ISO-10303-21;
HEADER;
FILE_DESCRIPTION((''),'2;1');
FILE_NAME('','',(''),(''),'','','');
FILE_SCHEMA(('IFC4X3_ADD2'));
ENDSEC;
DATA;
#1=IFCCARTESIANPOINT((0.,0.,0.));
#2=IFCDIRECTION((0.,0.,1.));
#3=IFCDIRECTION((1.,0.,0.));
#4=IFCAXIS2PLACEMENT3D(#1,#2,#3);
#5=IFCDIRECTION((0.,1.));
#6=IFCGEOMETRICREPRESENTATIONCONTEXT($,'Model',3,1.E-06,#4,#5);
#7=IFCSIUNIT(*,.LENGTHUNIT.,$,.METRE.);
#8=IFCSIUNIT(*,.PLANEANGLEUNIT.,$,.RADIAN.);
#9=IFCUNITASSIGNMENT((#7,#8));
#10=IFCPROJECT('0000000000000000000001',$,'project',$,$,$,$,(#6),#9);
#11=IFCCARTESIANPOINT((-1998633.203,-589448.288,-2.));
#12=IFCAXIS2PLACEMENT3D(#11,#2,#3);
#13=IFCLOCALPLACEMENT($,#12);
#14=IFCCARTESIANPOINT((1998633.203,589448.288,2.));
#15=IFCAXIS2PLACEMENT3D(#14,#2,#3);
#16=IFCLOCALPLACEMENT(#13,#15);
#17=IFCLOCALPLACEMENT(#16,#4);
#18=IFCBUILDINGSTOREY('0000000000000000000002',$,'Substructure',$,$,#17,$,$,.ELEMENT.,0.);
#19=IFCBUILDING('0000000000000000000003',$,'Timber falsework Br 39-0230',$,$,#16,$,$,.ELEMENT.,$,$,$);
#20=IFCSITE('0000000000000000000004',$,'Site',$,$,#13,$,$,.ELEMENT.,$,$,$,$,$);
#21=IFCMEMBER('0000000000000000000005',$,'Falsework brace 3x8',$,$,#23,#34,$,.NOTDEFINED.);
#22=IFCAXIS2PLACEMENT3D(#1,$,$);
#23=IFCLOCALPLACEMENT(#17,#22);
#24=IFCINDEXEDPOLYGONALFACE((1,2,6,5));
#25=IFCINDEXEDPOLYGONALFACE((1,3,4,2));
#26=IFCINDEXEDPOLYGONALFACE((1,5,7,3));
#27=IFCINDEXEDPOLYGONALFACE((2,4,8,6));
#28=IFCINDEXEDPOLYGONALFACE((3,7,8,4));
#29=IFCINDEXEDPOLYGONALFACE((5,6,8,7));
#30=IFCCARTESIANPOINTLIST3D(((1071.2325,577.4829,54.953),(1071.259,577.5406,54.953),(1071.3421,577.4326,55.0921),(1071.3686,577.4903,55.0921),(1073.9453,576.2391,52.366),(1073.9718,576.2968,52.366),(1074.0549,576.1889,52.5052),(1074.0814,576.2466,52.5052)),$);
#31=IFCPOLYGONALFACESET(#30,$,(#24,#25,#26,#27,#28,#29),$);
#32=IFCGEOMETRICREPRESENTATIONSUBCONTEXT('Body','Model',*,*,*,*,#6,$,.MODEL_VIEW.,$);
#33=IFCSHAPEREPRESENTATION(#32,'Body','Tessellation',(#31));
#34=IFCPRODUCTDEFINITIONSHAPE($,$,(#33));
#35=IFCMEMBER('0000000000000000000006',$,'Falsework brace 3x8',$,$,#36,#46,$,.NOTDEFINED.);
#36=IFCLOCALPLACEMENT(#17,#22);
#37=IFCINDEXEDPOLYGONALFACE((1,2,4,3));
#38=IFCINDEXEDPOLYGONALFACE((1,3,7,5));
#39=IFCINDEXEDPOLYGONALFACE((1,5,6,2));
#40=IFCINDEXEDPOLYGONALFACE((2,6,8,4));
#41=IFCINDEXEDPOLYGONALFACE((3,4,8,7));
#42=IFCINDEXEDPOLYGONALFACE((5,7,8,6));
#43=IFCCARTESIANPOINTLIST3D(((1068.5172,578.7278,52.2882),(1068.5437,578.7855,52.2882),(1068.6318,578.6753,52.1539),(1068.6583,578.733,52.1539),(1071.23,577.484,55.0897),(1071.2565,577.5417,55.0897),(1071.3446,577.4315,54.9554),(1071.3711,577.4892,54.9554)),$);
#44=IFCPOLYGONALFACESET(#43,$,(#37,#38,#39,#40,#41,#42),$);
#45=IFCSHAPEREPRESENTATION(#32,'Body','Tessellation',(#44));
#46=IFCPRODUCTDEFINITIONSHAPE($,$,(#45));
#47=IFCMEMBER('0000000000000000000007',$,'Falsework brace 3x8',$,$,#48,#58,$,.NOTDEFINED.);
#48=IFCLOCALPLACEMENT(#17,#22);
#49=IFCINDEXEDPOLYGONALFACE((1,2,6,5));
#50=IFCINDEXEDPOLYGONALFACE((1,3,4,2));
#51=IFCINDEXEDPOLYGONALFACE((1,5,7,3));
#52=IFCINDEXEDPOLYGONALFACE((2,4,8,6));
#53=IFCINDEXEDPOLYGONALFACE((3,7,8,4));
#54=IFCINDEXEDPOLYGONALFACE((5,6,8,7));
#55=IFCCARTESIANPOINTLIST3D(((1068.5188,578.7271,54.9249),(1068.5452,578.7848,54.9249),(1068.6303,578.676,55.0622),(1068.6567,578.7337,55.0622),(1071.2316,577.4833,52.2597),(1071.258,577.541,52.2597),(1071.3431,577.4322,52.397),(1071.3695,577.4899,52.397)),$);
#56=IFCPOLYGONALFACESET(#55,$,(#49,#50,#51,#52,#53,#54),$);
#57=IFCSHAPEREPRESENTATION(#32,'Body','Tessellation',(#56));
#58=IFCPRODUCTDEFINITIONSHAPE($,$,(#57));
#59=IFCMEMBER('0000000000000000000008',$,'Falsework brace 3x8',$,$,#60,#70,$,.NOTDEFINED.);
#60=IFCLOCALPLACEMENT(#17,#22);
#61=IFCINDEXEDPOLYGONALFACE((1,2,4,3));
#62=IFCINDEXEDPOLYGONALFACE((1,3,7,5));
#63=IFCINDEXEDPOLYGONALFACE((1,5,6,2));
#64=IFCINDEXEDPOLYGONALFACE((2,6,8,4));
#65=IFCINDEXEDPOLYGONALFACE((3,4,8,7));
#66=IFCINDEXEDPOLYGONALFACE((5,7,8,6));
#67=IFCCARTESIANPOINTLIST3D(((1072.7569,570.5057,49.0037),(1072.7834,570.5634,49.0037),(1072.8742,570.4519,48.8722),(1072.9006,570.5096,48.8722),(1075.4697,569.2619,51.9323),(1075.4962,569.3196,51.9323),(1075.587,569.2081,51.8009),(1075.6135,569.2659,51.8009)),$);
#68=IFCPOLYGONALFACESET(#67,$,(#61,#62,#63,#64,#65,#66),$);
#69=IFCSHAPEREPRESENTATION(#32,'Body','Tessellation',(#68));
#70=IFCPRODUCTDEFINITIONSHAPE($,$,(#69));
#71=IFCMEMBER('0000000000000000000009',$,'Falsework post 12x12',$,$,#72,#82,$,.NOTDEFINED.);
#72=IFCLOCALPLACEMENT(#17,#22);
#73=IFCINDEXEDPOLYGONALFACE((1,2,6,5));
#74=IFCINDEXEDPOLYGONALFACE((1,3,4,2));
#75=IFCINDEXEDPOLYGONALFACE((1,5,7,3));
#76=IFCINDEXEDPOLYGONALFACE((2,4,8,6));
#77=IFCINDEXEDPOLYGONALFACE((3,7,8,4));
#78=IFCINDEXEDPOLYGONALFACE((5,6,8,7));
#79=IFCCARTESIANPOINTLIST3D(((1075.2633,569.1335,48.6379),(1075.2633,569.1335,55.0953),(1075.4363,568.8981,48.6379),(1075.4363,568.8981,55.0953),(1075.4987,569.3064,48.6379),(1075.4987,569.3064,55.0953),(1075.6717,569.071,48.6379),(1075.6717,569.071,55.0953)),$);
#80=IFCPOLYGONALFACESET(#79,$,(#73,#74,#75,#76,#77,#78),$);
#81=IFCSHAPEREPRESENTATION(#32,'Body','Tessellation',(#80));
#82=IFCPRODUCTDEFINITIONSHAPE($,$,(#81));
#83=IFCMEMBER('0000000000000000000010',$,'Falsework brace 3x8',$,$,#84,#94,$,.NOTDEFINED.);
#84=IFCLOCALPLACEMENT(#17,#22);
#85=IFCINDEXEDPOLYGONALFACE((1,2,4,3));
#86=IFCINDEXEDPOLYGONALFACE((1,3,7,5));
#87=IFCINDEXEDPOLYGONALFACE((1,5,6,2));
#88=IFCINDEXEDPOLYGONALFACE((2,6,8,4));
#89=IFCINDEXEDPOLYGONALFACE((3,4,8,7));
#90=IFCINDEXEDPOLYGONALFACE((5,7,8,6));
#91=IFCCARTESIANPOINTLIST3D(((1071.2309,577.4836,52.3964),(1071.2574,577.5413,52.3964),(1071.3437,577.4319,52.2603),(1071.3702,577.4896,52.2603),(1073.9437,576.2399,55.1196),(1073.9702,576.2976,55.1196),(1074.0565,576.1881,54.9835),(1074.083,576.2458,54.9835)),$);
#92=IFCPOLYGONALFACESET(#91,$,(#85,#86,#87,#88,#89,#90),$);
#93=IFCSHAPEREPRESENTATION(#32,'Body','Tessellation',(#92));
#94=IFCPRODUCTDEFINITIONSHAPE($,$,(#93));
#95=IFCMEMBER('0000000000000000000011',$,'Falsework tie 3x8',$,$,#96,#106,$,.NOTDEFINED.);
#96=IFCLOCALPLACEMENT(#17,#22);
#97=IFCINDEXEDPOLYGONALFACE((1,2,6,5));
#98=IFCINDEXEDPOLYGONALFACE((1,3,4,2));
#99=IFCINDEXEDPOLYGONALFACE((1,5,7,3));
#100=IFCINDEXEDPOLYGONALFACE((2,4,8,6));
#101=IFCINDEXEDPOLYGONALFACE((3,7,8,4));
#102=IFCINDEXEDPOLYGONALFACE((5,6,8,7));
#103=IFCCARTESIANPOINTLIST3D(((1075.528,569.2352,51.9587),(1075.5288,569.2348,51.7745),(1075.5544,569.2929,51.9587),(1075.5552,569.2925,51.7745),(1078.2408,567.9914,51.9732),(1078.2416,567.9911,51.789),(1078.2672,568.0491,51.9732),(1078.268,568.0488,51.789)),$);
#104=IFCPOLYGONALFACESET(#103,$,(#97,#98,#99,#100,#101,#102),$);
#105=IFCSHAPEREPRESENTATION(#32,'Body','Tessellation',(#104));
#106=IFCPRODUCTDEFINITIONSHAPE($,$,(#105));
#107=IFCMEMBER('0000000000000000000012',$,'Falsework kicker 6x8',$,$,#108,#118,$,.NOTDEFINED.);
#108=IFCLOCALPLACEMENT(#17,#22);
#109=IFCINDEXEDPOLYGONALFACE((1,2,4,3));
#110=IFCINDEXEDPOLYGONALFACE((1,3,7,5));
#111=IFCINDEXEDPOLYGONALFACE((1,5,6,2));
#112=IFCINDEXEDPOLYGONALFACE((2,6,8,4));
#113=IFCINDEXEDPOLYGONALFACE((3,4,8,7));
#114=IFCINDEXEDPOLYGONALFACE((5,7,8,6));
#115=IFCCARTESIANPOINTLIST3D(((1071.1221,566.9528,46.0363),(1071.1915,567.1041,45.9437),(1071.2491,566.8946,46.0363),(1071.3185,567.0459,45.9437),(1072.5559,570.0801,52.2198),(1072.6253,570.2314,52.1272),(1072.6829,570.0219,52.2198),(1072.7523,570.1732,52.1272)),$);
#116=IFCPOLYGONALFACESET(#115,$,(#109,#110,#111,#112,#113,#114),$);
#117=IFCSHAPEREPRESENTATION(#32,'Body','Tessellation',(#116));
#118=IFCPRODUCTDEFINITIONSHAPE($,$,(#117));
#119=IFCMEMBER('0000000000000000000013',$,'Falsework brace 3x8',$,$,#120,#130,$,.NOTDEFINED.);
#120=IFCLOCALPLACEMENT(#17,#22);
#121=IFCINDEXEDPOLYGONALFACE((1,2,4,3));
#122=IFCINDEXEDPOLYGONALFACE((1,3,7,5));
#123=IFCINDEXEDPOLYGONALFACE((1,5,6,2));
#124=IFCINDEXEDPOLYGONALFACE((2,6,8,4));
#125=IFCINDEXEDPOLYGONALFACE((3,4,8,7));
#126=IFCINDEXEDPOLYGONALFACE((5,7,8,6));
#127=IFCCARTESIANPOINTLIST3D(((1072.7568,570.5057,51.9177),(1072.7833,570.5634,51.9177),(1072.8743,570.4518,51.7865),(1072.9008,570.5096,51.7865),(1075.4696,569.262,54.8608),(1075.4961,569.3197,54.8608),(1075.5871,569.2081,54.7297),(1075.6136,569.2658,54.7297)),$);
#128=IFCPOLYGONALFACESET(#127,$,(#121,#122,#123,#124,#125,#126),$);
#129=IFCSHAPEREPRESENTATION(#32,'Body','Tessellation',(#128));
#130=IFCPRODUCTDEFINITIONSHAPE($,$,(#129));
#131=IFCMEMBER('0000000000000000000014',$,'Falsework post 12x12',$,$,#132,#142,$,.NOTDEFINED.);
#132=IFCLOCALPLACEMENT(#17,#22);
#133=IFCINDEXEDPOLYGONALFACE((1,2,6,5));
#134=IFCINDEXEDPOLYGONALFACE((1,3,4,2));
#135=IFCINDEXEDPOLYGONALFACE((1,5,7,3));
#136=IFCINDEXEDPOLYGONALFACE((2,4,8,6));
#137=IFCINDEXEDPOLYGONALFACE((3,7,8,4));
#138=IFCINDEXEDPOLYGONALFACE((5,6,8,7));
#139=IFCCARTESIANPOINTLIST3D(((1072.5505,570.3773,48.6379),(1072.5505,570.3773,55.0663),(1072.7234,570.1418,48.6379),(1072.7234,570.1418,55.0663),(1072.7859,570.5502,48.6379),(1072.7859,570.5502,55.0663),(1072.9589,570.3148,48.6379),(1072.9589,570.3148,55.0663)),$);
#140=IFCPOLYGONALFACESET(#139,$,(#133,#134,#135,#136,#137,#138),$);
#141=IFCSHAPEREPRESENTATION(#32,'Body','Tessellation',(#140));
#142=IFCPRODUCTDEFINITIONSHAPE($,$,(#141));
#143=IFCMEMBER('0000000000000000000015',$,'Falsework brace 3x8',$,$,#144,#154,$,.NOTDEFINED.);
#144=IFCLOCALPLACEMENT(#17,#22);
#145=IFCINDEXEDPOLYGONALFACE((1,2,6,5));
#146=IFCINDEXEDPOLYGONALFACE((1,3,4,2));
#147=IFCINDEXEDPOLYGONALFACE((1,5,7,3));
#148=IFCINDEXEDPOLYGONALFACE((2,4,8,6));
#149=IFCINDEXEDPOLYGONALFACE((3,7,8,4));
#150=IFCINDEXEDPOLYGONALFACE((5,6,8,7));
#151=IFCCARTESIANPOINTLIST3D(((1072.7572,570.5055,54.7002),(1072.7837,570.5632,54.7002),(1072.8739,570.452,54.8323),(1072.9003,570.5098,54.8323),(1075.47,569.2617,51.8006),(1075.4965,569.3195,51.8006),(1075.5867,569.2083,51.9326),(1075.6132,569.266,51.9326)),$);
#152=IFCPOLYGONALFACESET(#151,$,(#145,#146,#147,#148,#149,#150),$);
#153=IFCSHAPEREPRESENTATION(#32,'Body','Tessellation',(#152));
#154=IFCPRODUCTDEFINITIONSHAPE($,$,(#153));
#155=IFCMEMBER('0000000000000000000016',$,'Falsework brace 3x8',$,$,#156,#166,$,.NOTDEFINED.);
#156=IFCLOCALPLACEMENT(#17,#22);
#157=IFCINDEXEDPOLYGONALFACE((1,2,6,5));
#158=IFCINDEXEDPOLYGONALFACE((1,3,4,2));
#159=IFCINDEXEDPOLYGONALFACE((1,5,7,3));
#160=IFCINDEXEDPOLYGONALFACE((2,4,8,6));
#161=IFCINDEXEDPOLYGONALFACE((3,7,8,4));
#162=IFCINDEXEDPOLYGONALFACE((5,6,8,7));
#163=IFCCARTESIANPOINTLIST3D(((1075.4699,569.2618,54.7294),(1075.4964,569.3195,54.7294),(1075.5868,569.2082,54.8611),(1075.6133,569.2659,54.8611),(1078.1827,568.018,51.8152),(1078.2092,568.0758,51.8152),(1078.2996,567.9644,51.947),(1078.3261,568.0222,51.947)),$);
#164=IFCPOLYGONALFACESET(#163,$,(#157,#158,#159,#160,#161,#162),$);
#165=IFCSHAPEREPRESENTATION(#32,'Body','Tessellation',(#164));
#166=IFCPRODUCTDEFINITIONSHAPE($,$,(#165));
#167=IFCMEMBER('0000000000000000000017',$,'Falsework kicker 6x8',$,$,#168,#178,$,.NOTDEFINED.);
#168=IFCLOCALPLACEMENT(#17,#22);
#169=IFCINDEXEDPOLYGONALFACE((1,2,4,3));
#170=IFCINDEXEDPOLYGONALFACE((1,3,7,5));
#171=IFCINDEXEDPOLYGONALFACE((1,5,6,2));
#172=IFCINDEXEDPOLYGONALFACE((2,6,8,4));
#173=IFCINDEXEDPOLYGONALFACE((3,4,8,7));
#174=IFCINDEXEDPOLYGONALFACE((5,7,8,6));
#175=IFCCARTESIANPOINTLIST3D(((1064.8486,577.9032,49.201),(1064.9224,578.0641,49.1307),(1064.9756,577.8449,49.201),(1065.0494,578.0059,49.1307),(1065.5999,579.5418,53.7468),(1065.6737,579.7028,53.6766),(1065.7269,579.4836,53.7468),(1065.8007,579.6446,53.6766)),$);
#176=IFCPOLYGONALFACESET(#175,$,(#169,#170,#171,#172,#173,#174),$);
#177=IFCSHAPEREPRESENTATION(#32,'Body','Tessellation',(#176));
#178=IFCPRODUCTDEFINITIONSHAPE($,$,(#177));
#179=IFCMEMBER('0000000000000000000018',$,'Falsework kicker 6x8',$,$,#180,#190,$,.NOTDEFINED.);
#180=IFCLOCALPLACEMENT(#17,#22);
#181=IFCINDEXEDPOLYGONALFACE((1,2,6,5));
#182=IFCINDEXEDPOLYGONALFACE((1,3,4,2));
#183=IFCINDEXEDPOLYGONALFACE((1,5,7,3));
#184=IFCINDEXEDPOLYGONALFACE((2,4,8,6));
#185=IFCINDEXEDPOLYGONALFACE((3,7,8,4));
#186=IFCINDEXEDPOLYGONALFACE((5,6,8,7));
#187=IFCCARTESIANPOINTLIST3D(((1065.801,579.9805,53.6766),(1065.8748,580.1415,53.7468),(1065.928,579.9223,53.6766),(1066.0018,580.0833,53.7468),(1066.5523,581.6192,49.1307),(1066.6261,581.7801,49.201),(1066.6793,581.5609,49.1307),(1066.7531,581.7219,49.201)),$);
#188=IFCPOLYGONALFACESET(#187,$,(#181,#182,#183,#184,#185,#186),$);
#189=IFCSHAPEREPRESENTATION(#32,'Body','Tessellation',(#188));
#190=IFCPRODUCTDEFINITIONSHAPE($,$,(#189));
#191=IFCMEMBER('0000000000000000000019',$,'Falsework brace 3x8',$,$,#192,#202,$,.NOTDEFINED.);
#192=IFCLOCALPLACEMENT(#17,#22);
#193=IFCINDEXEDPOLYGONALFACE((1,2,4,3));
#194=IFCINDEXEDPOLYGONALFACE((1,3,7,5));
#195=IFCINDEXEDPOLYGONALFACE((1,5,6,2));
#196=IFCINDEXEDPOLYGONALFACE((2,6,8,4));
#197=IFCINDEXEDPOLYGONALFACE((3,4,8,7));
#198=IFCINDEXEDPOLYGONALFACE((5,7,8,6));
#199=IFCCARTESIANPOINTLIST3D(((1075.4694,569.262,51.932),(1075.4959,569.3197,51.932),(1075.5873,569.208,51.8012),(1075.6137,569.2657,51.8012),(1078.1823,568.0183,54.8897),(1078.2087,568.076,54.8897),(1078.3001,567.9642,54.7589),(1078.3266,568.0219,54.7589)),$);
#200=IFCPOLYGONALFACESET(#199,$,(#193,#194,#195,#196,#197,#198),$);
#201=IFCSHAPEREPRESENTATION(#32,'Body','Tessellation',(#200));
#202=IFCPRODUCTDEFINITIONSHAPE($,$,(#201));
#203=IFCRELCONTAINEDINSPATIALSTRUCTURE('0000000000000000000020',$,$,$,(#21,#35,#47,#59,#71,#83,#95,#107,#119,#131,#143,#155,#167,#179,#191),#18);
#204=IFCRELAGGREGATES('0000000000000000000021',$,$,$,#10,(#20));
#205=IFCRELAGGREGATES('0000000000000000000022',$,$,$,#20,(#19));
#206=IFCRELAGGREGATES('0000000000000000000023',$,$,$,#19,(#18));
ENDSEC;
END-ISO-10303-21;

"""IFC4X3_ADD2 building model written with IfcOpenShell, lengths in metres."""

from ifc_helpers import new_model, si_unit, direction, frame, origin, origin_with_axes, origin_2d, place, context, subcontext, project, spatial, rectangle, extrude, element, save


model = new_model("IFC4X3_ADD2")

# Units and contexts
model_context = context("Model", 3, precision=1e-06, world=origin_with_axes(), true_north=direction((0.0, 1.0)))
body_context = subcontext(model_context, "Body", "Model", "MODEL_VIEW")
ifc_project = project(units=[si_unit("LENGTHUNIT", "METRE"), si_unit("PLANEANGLEUNIT", "RADIAN")], contexts=[model_context])

# Site, building, storey
site_placement = place(None, frame((-1998633.203, -589448.288, -2.0), z_axis=(0.0, 0.0, 1.0), x_axis=(1.0, 0.0, 0.0)))
site = spatial("IfcSite", under=ifc_project, at=site_placement, Name="Site", CompositionType="ELEMENT")
building_placement = place(site_placement, frame((1998633.203, 589448.288, 2.0), z_axis=(0.0, 0.0, 1.0), x_axis=(1.0, 0.0, 0.0)))
building = spatial("IfcBuilding", under=site, at=building_placement, Name="Timber falsework Br 39-0230", CompositionType="ELEMENT")
storey_placement = place(building_placement, origin_with_axes())
storey = spatial("IfcBuildingStorey", under=building, at=storey_placement, Name="Substructure", CompositionType="ELEMENT", Elevation=0.0)

# Members
member_1_placement = place(storey_placement, frame((1071.3005, 577.4866, 55.0226), z_axis=(0.686874, -0.314918, -0.655005), x_axis=(0.416765, 0.909014, 0.0)))
element("IfcMember", 1, at=member_1_placement, inside=storey, Name="Falsework brace 3x8", PredefinedType="NOTDEFINED", context=body_context, shape_type="SweptSolid", body=[
    extrude(rectangle(XDim=0.0635, YDim=0.1841, at=origin_2d()), origin(), (0.0, 0.0, 1.0), 3.9495),
])
member_2_placement = place(storey_placement, frame((1068.5877, 578.7304, 52.2211), z_axis=(0.662752, -0.303859, 0.684419), x_axis=(0.416765, 0.909014, 0.0)))
element("IfcMember", 2, at=member_2_placement, inside=storey, Name="Falsework brace 3x8", PredefinedType="NOTDEFINED", context=body_context, shape_type="SweptSolid", body=[
    extrude(rectangle(XDim=0.0635, YDim=0.1841, at=origin_2d()), origin(), (0.0, 0.0, 1.0), 4.0932),
])
member_3_placement = place(storey_placement, frame((1068.5877, 578.7304, 54.9936), z_axis=(0.677997, -0.310848, -0.666103), x_axis=(0.416765, 0.909014, 0.0)))
element("IfcMember", 3, at=member_3_placement, inside=storey, Name="Falsework brace 3x8", PredefinedType="NOTDEFINED", context=body_context, shape_type="SweptSolid", body=[
    extrude(rectangle(XDim=0.0635, YDim=0.1841, at=origin_2d()), origin(), (0.0, 0.0, 1.0), 4.0012),
])
member_4_placement = place(storey_placement, frame((1072.8288, 570.5076, 48.9379), z_axis=(0.648794, -0.297459, 0.700417), x_axis=(0.416765, 0.909014, 0.0)))
element("IfcMember", 4, at=member_4_placement, inside=storey, Name="Falsework brace 3x8", PredefinedType="NOTDEFINED", context=body_context, shape_type="SweptSolid", body=[
    extrude(rectangle(XDim=0.0635, YDim=0.1841, at=origin_2d()), origin(), (0.0, 0.0, 1.0), 4.1813),
])
member_5_placement = place(storey_placement, frame((1075.4675, 569.1022, 48.6379), z_axis=(0.0, 0.0, 1.0), x_axis=(-0.805928, -0.592013, 0.0)))
element("IfcMember", 5, at=member_5_placement, inside=storey, Name="Falsework post 12x12", PredefinedType="NOTDEFINED", context=body_context, shape_type="SweptSolid", body=[
    extrude(rectangle(XDim=0.2921, YDim=0.2921, at=origin_2d()), origin(), (0.0, 0.0, 1.0), 6.4573),
])
member_6_placement = place(storey_placement, frame((1071.3005, 577.4866, 52.3283), z_axis=(0.671475, -0.307858, 0.674051), x_axis=(0.416765, 0.909014, 0.0)))
element("IfcMember", 6, at=member_6_placement, inside=storey, Name="Falsework brace 3x8", PredefinedType="NOTDEFINED", context=body_context, shape_type="SweptSolid", body=[
    extrude(rectangle(XDim=0.0635, YDim=0.1841, at=origin_2d()), origin(), (0.0, 0.0, 1.0), 4.0401),
])
member_7_placement = place(storey_placement, frame((1075.5416, 569.2639, 51.8666), z_axis=(0.909003, -0.41676, 0.004859), x_axis=(0.416765, 0.909014, 0.0)))
element("IfcMember", 7, at=member_7_placement, inside=storey, Name="Falsework tie 3x8", PredefinedType="NOTDEFINED", context=body_context, shape_type="SweptSolid", body=[
    extrude(rectangle(XDim=0.0635, YDim=0.1841, at=origin_2d()), origin(), (0.0, 0.0, 1.0), 2.9844),
])
member_8_placement = place(storey_placement, frame((1072.6541, 570.1267, 52.1735), z_axis=(-0.202626, -0.441951, -0.873855), x_axis=(0.909014, -0.416765, 0.0)))
element("IfcMember", 8, at=member_8_placement, inside=storey, Name="Falsework kicker 6x8", PredefinedType="NOTDEFINED", context=body_context, shape_type="SweptSolid", body=[
    extrude(rectangle(XDim=0.1397, YDim=0.1905, at=origin_2d()), origin(), (0.0, 0.0, 1.0), 7.0761),
])
member_9_placement = place(storey_placement, frame((1072.8288, 570.5076, 51.8521), z_axis=(0.64722, -0.296738, 0.702178), x_axis=(0.416765, 0.909014, 0.0)))
element("IfcMember", 9, at=member_9_placement, inside=storey, Name="Falsework brace 3x8", PredefinedType="NOTDEFINED", context=body_context, shape_type="SweptSolid", body=[
    extrude(rectangle(XDim=0.0635, YDim=0.1841, at=origin_2d()), origin(), (0.0, 0.0, 1.0), 4.1915),
])
member_10_placement = place(storey_placement, frame((1072.7547, 570.346, 48.6379), z_axis=(0.0, 0.0, 1.0), x_axis=(-0.805928, -0.592013, 0.0)))
element("IfcMember", 10, at=member_10_placement, inside=storey, Name="Falsework post 12x12", PredefinedType="NOTDEFINED", context=body_context, shape_type="SweptSolid", body=[
    extrude(rectangle(XDim=0.2921, YDim=0.2921, at=origin_2d()), origin(), (0.0, 0.0, 1.0), 6.4283),
])
member_11_placement = place(storey_placement, frame((1072.8288, 570.5076, 54.7663), z_axis=(0.651953, -0.298908, -0.696858), x_axis=(0.416765, 0.909014, 0.0)))
element("IfcMember", 11, at=member_11_placement, inside=storey, Name="Falsework brace 3x8", PredefinedType="NOTDEFINED", context=body_context, shape_type="SweptSolid", body=[
    extrude(rectangle(XDim=0.0635, YDim=0.1841, at=origin_2d()), origin(), (0.0, 0.0, 1.0), 4.161),
])
member_12_placement = place(storey_placement, frame((1075.5416, 569.2639, 54.7953), z_axis=(0.650372, -0.298183, -0.698644), x_axis=(0.416765, 0.909014, 0.0)))
element("IfcMember", 12, at=member_12_placement, inside=storey, Name="Falsework brace 3x8", PredefinedType="NOTDEFINED", context=body_context, shape_type="SweptSolid", body=[
    extrude(rectangle(XDim=0.0635, YDim=0.1841, at=origin_2d()), origin(), (0.0, 0.0, 1.0), 4.1712),
])
for number, where, z_axis, x_axis, name in (
    (13, (1065.7003, 579.5932, 53.7117), (-0.153631, -0.335087, -0.929578), (0.909014, -0.416765, 0.0), "Falsework kicker 6x8"),
    (14, (1065.9014, 580.0319, 53.7117), (0.153631, 0.335087, -0.929578), (-0.909014, 0.416765, 0.0), "Falsework kicker 6x8"),
):
    element("IfcMember", number, at=place(storey_placement, frame(where, z_axis=z_axis, x_axis=x_axis)), inside=storey, Name=name, PredefinedType="NOTDEFINED", context=body_context, shape_type="SweptSolid", body=[
        extrude(rectangle(XDim=0.1397, YDim=0.1905, at=origin_2d()), origin(), (0.0, 0.0, 1.0), 4.8902),
    ])
member_13_placement = place(storey_placement, frame((1075.5416, 569.2639, 51.8666), z_axis=(0.645649, -0.296018, 0.703925), x_axis=(0.416765, 0.909014, 0.0)))
element("IfcMember", 15, at=member_13_placement, inside=storey, Name="Falsework brace 3x8", PredefinedType="NOTDEFINED", context=body_context, shape_type="SweptSolid", body=[
    extrude(rectangle(XDim=0.0635, YDim=0.1841, at=origin_2d()), origin(), (0.0, 0.0, 1.0), 4.2017),
])

save(model, "model.ifc")
